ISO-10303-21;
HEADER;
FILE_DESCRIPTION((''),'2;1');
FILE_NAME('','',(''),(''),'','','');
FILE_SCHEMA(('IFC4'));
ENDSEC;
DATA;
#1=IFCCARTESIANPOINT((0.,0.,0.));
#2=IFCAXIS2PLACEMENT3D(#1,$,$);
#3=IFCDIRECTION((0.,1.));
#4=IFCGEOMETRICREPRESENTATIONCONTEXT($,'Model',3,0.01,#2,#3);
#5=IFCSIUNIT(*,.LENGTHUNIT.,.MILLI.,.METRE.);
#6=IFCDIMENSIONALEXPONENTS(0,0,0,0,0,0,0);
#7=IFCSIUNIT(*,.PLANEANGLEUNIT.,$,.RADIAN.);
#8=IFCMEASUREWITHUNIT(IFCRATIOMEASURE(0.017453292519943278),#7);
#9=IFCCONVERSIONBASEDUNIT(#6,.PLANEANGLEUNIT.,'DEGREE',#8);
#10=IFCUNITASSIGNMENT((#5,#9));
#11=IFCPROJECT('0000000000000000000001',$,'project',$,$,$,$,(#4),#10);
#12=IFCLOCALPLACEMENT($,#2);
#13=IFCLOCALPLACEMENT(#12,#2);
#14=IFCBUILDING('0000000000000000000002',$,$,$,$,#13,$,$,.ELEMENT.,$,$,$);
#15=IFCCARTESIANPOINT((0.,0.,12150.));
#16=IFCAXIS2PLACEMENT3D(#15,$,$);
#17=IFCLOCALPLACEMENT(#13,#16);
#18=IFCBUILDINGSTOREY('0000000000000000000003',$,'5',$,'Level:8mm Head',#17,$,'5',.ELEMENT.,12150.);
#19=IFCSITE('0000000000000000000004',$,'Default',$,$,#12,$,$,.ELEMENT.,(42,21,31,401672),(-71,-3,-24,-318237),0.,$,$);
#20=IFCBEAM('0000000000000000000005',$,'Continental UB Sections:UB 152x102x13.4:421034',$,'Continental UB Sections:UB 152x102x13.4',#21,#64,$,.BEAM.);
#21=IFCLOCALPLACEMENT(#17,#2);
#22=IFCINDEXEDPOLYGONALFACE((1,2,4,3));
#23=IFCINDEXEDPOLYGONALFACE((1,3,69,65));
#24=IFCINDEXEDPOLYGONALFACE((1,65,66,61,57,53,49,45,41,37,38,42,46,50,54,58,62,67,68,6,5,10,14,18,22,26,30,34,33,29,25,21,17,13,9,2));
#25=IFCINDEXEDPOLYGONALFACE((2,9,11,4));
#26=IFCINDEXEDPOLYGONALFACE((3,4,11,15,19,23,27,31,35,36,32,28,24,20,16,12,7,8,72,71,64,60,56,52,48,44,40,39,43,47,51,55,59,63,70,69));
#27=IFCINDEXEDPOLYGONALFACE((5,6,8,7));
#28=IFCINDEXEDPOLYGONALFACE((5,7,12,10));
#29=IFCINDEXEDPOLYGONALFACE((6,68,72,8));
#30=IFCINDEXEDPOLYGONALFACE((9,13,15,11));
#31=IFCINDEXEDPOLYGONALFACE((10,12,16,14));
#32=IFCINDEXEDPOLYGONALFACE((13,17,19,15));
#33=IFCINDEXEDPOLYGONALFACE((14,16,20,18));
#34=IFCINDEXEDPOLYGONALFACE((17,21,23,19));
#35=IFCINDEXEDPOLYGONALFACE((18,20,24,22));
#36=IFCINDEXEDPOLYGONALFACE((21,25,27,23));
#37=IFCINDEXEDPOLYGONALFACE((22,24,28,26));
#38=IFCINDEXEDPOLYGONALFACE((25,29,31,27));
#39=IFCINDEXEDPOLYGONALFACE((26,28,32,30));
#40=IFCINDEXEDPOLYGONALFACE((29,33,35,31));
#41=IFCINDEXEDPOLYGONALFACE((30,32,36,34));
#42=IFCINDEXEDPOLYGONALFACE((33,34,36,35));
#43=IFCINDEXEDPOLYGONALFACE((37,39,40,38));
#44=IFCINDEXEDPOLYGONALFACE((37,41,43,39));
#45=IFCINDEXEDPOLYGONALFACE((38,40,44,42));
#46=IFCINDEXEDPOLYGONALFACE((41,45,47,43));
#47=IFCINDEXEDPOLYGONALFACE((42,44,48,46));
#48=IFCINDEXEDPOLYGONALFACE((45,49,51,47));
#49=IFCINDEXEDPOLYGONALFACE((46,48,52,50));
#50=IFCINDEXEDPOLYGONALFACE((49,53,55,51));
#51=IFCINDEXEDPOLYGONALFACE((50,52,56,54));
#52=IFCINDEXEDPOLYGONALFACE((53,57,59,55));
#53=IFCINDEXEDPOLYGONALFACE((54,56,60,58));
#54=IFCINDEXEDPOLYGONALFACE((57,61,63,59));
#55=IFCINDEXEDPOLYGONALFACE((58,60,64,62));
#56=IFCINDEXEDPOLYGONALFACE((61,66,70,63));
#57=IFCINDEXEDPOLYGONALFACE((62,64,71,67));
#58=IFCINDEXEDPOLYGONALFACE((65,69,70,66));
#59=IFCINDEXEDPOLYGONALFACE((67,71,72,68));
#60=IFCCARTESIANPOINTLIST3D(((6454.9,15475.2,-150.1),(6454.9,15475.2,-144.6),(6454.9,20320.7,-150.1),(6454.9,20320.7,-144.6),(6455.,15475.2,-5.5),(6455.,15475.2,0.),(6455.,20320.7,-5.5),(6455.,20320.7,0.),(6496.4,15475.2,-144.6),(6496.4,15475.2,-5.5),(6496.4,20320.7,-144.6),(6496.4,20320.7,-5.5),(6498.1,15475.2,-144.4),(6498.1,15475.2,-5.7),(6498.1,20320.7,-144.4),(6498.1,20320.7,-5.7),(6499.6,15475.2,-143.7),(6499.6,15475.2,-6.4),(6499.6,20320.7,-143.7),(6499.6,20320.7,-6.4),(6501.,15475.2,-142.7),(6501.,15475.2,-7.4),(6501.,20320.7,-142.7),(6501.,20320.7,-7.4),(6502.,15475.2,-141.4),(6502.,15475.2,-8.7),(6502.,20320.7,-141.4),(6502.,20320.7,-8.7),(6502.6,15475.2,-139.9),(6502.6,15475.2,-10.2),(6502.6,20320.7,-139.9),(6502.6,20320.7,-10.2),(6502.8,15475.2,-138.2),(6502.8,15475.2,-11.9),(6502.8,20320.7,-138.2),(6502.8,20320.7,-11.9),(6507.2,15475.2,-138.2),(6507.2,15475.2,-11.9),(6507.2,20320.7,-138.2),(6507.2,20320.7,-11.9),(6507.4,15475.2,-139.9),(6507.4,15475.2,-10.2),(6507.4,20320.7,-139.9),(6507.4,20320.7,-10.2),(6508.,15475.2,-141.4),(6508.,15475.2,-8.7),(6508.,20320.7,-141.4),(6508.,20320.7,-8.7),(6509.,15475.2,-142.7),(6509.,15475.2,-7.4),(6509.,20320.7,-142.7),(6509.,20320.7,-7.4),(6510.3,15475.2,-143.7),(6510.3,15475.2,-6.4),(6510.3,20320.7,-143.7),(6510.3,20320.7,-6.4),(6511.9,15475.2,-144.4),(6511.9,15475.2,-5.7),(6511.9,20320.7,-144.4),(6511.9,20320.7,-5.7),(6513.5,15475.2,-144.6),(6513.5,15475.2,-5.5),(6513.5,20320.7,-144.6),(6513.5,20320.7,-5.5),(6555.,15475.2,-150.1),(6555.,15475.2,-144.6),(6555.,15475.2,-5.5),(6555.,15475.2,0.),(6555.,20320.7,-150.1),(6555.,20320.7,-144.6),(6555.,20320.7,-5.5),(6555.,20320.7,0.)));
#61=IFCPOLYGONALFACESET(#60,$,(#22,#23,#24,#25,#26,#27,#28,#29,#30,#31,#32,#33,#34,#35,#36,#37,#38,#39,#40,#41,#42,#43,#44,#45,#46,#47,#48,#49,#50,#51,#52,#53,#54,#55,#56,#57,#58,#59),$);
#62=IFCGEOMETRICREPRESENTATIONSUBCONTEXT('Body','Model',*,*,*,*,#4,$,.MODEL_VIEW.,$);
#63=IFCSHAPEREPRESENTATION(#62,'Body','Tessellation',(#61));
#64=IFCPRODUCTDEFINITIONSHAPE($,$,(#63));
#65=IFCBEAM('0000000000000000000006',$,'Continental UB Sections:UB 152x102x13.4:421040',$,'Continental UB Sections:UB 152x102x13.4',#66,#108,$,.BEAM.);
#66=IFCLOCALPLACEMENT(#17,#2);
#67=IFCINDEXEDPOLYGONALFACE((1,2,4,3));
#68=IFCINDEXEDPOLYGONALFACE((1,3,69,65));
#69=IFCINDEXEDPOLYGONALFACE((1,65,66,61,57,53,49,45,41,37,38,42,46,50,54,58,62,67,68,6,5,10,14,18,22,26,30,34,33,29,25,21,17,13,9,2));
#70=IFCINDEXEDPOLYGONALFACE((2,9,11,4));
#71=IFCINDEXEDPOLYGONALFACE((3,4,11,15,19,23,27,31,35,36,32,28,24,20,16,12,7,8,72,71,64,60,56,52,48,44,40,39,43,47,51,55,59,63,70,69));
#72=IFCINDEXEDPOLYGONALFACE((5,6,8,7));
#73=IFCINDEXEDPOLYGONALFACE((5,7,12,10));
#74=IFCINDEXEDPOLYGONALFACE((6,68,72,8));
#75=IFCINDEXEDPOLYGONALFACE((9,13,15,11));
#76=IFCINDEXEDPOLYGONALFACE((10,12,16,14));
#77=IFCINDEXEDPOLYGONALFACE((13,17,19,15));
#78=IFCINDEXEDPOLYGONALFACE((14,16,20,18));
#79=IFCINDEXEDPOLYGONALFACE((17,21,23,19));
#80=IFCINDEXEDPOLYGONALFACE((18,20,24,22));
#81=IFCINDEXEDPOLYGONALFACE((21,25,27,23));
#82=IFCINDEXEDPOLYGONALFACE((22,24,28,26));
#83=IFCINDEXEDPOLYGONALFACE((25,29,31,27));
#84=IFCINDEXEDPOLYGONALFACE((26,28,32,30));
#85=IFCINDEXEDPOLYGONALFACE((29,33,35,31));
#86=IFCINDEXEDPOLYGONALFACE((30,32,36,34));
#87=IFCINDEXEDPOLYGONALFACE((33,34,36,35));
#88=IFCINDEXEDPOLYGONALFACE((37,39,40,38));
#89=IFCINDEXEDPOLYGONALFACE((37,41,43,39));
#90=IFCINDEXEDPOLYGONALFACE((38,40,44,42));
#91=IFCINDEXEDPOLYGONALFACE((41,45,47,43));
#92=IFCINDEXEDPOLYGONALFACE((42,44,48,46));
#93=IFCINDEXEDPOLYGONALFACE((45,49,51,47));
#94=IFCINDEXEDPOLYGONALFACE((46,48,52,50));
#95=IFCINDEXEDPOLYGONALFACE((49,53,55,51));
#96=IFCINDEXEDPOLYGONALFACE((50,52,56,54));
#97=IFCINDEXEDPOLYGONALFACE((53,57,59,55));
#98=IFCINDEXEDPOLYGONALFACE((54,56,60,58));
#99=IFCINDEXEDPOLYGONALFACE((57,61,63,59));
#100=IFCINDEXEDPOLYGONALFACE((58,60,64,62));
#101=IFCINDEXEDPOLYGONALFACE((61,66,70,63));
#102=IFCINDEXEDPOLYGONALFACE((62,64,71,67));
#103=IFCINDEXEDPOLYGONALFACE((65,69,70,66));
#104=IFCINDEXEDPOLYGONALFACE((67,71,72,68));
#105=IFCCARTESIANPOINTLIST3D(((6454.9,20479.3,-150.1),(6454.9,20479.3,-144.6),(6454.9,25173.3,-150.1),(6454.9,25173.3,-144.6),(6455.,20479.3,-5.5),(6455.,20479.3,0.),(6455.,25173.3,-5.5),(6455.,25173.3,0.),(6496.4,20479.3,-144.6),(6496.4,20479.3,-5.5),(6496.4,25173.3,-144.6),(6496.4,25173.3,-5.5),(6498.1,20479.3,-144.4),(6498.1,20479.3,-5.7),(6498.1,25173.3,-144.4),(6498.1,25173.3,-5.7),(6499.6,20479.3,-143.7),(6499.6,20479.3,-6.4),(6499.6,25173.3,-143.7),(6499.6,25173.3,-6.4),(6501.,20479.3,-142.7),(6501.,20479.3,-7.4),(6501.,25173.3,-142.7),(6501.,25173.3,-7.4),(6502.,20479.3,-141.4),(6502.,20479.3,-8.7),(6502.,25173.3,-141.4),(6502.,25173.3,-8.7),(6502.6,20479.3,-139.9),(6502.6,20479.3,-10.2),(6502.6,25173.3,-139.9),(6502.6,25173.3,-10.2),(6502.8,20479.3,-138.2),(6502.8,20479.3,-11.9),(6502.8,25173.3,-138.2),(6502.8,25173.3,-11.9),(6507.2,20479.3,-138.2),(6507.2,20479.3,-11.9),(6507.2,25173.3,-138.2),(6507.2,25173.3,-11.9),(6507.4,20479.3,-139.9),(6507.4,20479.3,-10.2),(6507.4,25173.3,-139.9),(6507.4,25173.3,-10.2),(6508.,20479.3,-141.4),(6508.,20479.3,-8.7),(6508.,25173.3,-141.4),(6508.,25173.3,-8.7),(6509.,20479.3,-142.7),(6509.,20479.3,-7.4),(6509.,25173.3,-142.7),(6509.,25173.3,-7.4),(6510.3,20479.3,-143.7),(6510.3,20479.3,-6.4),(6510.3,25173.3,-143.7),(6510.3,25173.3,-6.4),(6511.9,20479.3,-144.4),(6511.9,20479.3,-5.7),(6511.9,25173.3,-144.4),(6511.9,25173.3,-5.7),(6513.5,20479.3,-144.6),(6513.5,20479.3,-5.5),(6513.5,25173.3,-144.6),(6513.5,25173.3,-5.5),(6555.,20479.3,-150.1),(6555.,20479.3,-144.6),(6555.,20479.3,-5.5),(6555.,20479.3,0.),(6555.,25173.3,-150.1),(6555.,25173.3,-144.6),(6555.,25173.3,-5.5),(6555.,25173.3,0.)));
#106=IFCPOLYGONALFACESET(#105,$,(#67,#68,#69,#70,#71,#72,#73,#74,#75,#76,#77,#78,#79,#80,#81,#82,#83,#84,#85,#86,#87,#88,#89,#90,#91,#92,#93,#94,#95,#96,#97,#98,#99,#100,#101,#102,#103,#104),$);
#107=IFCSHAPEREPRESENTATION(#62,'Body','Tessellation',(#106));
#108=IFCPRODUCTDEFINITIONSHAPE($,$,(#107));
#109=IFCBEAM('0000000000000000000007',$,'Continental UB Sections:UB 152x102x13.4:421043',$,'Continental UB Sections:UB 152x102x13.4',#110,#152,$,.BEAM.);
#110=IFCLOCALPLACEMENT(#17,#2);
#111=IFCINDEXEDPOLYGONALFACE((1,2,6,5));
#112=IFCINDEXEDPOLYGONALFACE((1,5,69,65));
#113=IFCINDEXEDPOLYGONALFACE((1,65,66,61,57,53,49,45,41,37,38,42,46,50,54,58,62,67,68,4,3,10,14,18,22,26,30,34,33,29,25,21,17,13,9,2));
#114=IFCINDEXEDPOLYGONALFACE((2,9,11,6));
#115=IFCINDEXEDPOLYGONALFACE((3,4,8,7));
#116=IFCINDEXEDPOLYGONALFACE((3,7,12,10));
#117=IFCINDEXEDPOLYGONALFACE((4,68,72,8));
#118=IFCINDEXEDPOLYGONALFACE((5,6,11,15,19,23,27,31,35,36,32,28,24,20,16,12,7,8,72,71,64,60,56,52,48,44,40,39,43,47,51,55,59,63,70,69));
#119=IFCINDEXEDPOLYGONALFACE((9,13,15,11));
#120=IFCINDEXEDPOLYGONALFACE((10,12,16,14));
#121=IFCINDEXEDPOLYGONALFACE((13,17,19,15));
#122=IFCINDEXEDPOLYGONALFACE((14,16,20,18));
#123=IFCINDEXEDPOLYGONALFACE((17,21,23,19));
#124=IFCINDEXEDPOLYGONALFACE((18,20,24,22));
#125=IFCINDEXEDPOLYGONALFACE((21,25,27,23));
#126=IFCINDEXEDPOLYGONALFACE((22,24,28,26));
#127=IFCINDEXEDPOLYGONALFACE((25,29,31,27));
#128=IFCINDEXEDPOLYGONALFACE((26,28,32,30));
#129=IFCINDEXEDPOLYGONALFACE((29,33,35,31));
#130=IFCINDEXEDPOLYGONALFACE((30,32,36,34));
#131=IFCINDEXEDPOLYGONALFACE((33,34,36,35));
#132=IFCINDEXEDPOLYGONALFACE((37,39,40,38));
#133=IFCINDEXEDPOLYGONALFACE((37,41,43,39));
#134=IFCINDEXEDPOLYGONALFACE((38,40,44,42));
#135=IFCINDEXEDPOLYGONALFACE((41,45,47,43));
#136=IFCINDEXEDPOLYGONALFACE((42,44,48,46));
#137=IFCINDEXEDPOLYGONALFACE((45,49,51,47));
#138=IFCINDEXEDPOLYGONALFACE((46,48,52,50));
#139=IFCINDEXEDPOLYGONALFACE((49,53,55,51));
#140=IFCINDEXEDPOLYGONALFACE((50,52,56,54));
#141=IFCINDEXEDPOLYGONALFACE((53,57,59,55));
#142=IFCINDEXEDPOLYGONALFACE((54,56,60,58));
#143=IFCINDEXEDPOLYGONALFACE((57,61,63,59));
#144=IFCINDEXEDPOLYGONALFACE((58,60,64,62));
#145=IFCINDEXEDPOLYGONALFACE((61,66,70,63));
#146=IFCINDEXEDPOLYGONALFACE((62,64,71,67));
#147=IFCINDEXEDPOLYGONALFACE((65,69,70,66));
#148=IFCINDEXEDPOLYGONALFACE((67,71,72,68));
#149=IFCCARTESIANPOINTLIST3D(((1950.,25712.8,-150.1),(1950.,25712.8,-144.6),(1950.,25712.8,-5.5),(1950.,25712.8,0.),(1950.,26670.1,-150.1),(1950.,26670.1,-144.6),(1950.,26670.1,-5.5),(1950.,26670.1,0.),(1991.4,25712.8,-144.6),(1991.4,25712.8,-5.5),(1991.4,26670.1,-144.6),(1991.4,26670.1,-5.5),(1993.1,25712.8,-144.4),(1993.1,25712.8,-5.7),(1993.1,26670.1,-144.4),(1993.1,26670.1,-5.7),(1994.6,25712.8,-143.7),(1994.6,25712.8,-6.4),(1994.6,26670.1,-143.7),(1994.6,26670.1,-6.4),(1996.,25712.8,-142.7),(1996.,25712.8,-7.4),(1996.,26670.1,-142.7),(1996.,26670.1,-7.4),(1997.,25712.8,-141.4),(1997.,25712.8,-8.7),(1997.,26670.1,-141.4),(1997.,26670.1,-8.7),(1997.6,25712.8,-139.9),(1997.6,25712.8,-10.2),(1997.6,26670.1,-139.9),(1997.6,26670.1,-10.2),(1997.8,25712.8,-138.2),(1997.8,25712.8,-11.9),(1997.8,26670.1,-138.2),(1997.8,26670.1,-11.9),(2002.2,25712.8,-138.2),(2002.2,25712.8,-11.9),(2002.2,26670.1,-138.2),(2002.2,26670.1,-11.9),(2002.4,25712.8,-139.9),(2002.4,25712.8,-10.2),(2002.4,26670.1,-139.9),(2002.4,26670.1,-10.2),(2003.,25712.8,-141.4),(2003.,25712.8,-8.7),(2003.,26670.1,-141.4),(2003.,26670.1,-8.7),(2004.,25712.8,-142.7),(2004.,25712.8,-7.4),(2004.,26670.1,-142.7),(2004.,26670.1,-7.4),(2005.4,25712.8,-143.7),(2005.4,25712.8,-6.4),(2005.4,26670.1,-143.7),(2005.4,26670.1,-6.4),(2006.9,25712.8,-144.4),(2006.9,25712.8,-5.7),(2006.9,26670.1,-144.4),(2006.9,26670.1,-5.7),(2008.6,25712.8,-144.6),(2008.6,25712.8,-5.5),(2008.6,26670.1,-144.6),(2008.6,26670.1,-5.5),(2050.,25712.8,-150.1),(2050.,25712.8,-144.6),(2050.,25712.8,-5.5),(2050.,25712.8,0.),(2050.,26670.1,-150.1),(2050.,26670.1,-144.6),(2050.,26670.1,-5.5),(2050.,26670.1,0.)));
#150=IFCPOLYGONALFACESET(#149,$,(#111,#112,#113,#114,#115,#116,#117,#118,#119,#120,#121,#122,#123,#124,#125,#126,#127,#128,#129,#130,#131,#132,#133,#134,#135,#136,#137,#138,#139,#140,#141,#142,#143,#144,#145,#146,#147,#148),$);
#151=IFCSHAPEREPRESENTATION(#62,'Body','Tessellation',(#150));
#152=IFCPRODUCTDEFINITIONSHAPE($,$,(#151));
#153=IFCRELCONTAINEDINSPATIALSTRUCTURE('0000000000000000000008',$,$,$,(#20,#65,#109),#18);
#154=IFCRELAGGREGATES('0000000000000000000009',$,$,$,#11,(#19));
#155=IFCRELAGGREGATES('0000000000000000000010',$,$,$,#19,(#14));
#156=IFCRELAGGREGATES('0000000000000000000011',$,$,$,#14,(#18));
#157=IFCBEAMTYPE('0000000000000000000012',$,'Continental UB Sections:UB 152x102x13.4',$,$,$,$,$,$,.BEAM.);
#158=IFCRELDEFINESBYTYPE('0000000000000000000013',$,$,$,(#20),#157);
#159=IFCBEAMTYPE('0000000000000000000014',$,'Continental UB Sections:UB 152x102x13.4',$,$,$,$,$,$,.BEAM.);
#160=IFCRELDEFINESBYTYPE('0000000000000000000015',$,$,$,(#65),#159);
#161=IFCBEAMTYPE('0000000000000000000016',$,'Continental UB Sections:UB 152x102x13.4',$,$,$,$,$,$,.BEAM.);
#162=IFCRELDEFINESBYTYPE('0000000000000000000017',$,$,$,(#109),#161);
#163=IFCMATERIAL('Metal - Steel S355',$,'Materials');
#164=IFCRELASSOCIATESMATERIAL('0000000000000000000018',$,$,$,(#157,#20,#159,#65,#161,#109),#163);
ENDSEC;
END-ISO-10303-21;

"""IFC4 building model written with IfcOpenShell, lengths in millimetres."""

from ifc_helpers import new_model, entity, si_unit, converted_unit, direction, frame, origin, place, context, subcontext, project, spatial, line, arc, indexed_curve, outline, extrude, source, transform, mapped, material, type_object, type_shapes, element, save


model = new_model("IFC4")

# Units and contexts
model_context = context("Model", 3, precision=0.01, world=origin(), true_north=direction((0.0, 1.0)))
body_context = subcontext(model_context, "Body", "Model", "MODEL_VIEW")
ifc_project = project(units=[si_unit("LENGTHUNIT", "METRE", prefix="MILLI"), converted_unit("PLANEANGLEUNIT", "DEGREE", entity("IfcRatioMeasure", 0.017453292519943278), si_unit("PLANEANGLEUNIT", "RADIAN"), dimensions=[0, 0, 0, 0, 0, 0, 0])], contexts=[model_context])

# Site, building, storey
site_placement = place(None, origin())
site = spatial("IfcSite", under=ifc_project, at=site_placement, Name="Default", CompositionType="ELEMENT", RefLatitude=(42, 21, 31, 401672), RefLongitude=(-71, -3, -24, -318237), RefElevation=0.0)
building_placement = place(site_placement, origin())
building = spatial("IfcBuilding", under=site, at=building_placement, CompositionType="ELEMENT")
storey_placement = place(building_placement, frame((0.0, 0.0, 12150.0)))
storey = spatial("IfcBuildingStorey", under=building, at=storey_placement, Name="5", ObjectType="Level:8mm Head", LongName="5", CompositionType="ELEMENT", Elevation=12150.0)

# Beams
ifc_material = material(Name="Metal - Steel S355", Category="Materials")
beam_type_1 = type_object("IfcBeamType", Name="Continental UB Sections:UB 152x102x13.4", PredefinedType="BEAM", material=ifc_material)
shared_shape_1 = source(origin(), body_context, "Body", "SweptSolid", [
    extrude(outline(indexed_curve([(-75.0, -50.1), (-69.6, -50.1), (-69.6, -8.5), (-67.7, -4.0), (-63.2, -2.1), (63.1, -2.1), (67.7, -4.0), (69.5, -8.5), (69.5, -50.1), (75.1, -50.1), (75.1, 50.1), (69.5, 50.1), (69.5, 8.6), (67.7, 4.0), (63.1, 2.2), (-63.2, 2.2), (-67.7, 4.0), (-69.6, 8.6), (-69.6, 50.0), (-75.0, 50.0)], segments=[line(1, 2, 3), arc(3, 4, 5), line(5, 6), arc(6, 7, 8), line(8, 9, 10, 11, 12, 13), arc(13, 14, 15), line(15, 16), arc(16, 17, 18), line(18, 19, 20, 1)], self_intersect=False)), frame((-2424.8, 0.0, 0.0), z_axis=(1.0, 0.0, 0.0), x_axis=(0.0, 0.0, -1.0)), (0.0, 0.0, 1.0), 4845.5),
])
type_shapes(beam_type_1, [shared_shape_1])
beam_1_placement = place(storey_placement, frame((6505.0, 17900.0, -75.1), z_axis=(0.0, 0.0, 1.0), x_axis=(0.0, 1.0, 0.0)))
element("IfcBeam", 1, at=beam_1_placement, inside=storey, type_object=beam_type_1, material=ifc_material, Name="Continental UB Sections:UB 152x102x13.4:421034", ObjectType="Continental UB Sections:UB 152x102x13.4", PredefinedType="BEAM", context=body_context, shape_type="MappedRepresentation", body=[
    mapped(shared_shape_1, transform((0.0, 0.0, 0.0), scale=1.0)),
])
beam_type_2 = type_object("IfcBeamType", Name="Continental UB Sections:UB 152x102x13.4", PredefinedType="BEAM", material=ifc_material)
shared_shape_2 = source(origin(), body_context, "Body", "SweptSolid", [
    extrude(outline(indexed_curve([(-75.0, -50.1), (-69.6, -50.1), (-69.6, -8.5), (-67.7, -4.0), (-63.2, -2.1), (63.1, -2.1), (67.7, -4.0), (69.5, -8.5), (69.5, -50.1), (75.1, -50.1), (75.1, 50.1), (69.5, 50.1), (69.5, 8.6), (67.7, 4.0), (63.1, 2.2), (-63.2, 2.2), (-67.7, 4.0), (-69.6, 8.6), (-69.6, 50.0), (-75.0, 50.0)], segments=[line(1, 2, 3), arc(3, 4, 5), line(5, 6), arc(6, 7, 8), line(8, 9, 10, 11, 12, 13), arc(13, 14, 15), line(15, 16), arc(16, 17, 18), line(18, 19, 20, 1)], self_intersect=False)), frame((-2570.7, 0.0, 0.0), z_axis=(1.0, 0.0, 0.0), x_axis=(0.0, 0.0, -1.0)), (0.0, 0.0, 1.0), 4694.0),
])
type_shapes(beam_type_2, [shared_shape_2])
beam_2_placement = place(storey_placement, frame((6505.0, 23050.0, -75.1), z_axis=(0.0, 0.0, 1.0), x_axis=(0.0, 1.0, 0.0)))
element("IfcBeam", 2, at=beam_2_placement, inside=storey, type_object=beam_type_2, material=ifc_material, Name="Continental UB Sections:UB 152x102x13.4:421040", ObjectType="Continental UB Sections:UB 152x102x13.4", PredefinedType="BEAM", context=body_context, shape_type="MappedRepresentation", body=[
    mapped(shared_shape_2, transform((0.0, 0.0, 0.0), scale=1.0)),
])
beam_type_3 = type_object("IfcBeamType", Name="Continental UB Sections:UB 152x102x13.4", PredefinedType="BEAM", material=ifc_material)
shared_shape_3 = source(origin(), body_context, "Body", "SweptSolid", [
    extrude(outline(indexed_curve([(-75.0, -50.1), (-69.6, -50.1), (-69.6, -8.5), (-67.7, -4.0), (-63.2, -2.1), (63.1, -2.1), (67.7, -4.0), (69.5, -8.5), (69.5, -50.1), (75.1, -50.1), (75.1, 50.1), (69.5, 50.1), (69.5, 8.6), (67.7, 4.0), (63.1, 2.2), (-63.2, 2.2), (-67.7, 4.0), (-69.6, 8.6), (-69.6, 50.0), (-75.0, 50.0)], segments=[line(1, 2, 3), arc(3, 4, 5), line(5, 6), arc(6, 7, 8), line(8, 9, 10, 11, 12, 13), arc(13, 14, 15), line(15, 16), arc(16, 17, 18), line(18, 19, 20, 1)], self_intersect=False)), frame((-447.2, 0.0, 0.0), z_axis=(1.0, 0.0, 0.0), x_axis=(0.0, 0.0, -1.0)), (0.0, 0.0, 1.0), 957.3),
])
type_shapes(beam_type_3, [shared_shape_3])
for number, where, z_axis, x_axis, name in (
    (3, (2000.0, 26160.0, -75.1), (0.0, 0.0, 1.0), (0.0, 1.0, 0.0), "Continental UB Sections:UB 152x102x13.4:421043"),
):
    element("IfcBeam", number, at=place(storey_placement, frame(where, z_axis=z_axis, x_axis=x_axis)), inside=storey, type_object=beam_type_3, material=ifc_material, Name=name, ObjectType="Continental UB Sections:UB 152x102x13.4", PredefinedType="BEAM", context=body_context, shape_type="MappedRepresentation", body=[
        mapped(shared_shape_3, transform((0.0, 0.0, 0.0), scale=1.0)),
    ])

save(model, "model.ifc")
